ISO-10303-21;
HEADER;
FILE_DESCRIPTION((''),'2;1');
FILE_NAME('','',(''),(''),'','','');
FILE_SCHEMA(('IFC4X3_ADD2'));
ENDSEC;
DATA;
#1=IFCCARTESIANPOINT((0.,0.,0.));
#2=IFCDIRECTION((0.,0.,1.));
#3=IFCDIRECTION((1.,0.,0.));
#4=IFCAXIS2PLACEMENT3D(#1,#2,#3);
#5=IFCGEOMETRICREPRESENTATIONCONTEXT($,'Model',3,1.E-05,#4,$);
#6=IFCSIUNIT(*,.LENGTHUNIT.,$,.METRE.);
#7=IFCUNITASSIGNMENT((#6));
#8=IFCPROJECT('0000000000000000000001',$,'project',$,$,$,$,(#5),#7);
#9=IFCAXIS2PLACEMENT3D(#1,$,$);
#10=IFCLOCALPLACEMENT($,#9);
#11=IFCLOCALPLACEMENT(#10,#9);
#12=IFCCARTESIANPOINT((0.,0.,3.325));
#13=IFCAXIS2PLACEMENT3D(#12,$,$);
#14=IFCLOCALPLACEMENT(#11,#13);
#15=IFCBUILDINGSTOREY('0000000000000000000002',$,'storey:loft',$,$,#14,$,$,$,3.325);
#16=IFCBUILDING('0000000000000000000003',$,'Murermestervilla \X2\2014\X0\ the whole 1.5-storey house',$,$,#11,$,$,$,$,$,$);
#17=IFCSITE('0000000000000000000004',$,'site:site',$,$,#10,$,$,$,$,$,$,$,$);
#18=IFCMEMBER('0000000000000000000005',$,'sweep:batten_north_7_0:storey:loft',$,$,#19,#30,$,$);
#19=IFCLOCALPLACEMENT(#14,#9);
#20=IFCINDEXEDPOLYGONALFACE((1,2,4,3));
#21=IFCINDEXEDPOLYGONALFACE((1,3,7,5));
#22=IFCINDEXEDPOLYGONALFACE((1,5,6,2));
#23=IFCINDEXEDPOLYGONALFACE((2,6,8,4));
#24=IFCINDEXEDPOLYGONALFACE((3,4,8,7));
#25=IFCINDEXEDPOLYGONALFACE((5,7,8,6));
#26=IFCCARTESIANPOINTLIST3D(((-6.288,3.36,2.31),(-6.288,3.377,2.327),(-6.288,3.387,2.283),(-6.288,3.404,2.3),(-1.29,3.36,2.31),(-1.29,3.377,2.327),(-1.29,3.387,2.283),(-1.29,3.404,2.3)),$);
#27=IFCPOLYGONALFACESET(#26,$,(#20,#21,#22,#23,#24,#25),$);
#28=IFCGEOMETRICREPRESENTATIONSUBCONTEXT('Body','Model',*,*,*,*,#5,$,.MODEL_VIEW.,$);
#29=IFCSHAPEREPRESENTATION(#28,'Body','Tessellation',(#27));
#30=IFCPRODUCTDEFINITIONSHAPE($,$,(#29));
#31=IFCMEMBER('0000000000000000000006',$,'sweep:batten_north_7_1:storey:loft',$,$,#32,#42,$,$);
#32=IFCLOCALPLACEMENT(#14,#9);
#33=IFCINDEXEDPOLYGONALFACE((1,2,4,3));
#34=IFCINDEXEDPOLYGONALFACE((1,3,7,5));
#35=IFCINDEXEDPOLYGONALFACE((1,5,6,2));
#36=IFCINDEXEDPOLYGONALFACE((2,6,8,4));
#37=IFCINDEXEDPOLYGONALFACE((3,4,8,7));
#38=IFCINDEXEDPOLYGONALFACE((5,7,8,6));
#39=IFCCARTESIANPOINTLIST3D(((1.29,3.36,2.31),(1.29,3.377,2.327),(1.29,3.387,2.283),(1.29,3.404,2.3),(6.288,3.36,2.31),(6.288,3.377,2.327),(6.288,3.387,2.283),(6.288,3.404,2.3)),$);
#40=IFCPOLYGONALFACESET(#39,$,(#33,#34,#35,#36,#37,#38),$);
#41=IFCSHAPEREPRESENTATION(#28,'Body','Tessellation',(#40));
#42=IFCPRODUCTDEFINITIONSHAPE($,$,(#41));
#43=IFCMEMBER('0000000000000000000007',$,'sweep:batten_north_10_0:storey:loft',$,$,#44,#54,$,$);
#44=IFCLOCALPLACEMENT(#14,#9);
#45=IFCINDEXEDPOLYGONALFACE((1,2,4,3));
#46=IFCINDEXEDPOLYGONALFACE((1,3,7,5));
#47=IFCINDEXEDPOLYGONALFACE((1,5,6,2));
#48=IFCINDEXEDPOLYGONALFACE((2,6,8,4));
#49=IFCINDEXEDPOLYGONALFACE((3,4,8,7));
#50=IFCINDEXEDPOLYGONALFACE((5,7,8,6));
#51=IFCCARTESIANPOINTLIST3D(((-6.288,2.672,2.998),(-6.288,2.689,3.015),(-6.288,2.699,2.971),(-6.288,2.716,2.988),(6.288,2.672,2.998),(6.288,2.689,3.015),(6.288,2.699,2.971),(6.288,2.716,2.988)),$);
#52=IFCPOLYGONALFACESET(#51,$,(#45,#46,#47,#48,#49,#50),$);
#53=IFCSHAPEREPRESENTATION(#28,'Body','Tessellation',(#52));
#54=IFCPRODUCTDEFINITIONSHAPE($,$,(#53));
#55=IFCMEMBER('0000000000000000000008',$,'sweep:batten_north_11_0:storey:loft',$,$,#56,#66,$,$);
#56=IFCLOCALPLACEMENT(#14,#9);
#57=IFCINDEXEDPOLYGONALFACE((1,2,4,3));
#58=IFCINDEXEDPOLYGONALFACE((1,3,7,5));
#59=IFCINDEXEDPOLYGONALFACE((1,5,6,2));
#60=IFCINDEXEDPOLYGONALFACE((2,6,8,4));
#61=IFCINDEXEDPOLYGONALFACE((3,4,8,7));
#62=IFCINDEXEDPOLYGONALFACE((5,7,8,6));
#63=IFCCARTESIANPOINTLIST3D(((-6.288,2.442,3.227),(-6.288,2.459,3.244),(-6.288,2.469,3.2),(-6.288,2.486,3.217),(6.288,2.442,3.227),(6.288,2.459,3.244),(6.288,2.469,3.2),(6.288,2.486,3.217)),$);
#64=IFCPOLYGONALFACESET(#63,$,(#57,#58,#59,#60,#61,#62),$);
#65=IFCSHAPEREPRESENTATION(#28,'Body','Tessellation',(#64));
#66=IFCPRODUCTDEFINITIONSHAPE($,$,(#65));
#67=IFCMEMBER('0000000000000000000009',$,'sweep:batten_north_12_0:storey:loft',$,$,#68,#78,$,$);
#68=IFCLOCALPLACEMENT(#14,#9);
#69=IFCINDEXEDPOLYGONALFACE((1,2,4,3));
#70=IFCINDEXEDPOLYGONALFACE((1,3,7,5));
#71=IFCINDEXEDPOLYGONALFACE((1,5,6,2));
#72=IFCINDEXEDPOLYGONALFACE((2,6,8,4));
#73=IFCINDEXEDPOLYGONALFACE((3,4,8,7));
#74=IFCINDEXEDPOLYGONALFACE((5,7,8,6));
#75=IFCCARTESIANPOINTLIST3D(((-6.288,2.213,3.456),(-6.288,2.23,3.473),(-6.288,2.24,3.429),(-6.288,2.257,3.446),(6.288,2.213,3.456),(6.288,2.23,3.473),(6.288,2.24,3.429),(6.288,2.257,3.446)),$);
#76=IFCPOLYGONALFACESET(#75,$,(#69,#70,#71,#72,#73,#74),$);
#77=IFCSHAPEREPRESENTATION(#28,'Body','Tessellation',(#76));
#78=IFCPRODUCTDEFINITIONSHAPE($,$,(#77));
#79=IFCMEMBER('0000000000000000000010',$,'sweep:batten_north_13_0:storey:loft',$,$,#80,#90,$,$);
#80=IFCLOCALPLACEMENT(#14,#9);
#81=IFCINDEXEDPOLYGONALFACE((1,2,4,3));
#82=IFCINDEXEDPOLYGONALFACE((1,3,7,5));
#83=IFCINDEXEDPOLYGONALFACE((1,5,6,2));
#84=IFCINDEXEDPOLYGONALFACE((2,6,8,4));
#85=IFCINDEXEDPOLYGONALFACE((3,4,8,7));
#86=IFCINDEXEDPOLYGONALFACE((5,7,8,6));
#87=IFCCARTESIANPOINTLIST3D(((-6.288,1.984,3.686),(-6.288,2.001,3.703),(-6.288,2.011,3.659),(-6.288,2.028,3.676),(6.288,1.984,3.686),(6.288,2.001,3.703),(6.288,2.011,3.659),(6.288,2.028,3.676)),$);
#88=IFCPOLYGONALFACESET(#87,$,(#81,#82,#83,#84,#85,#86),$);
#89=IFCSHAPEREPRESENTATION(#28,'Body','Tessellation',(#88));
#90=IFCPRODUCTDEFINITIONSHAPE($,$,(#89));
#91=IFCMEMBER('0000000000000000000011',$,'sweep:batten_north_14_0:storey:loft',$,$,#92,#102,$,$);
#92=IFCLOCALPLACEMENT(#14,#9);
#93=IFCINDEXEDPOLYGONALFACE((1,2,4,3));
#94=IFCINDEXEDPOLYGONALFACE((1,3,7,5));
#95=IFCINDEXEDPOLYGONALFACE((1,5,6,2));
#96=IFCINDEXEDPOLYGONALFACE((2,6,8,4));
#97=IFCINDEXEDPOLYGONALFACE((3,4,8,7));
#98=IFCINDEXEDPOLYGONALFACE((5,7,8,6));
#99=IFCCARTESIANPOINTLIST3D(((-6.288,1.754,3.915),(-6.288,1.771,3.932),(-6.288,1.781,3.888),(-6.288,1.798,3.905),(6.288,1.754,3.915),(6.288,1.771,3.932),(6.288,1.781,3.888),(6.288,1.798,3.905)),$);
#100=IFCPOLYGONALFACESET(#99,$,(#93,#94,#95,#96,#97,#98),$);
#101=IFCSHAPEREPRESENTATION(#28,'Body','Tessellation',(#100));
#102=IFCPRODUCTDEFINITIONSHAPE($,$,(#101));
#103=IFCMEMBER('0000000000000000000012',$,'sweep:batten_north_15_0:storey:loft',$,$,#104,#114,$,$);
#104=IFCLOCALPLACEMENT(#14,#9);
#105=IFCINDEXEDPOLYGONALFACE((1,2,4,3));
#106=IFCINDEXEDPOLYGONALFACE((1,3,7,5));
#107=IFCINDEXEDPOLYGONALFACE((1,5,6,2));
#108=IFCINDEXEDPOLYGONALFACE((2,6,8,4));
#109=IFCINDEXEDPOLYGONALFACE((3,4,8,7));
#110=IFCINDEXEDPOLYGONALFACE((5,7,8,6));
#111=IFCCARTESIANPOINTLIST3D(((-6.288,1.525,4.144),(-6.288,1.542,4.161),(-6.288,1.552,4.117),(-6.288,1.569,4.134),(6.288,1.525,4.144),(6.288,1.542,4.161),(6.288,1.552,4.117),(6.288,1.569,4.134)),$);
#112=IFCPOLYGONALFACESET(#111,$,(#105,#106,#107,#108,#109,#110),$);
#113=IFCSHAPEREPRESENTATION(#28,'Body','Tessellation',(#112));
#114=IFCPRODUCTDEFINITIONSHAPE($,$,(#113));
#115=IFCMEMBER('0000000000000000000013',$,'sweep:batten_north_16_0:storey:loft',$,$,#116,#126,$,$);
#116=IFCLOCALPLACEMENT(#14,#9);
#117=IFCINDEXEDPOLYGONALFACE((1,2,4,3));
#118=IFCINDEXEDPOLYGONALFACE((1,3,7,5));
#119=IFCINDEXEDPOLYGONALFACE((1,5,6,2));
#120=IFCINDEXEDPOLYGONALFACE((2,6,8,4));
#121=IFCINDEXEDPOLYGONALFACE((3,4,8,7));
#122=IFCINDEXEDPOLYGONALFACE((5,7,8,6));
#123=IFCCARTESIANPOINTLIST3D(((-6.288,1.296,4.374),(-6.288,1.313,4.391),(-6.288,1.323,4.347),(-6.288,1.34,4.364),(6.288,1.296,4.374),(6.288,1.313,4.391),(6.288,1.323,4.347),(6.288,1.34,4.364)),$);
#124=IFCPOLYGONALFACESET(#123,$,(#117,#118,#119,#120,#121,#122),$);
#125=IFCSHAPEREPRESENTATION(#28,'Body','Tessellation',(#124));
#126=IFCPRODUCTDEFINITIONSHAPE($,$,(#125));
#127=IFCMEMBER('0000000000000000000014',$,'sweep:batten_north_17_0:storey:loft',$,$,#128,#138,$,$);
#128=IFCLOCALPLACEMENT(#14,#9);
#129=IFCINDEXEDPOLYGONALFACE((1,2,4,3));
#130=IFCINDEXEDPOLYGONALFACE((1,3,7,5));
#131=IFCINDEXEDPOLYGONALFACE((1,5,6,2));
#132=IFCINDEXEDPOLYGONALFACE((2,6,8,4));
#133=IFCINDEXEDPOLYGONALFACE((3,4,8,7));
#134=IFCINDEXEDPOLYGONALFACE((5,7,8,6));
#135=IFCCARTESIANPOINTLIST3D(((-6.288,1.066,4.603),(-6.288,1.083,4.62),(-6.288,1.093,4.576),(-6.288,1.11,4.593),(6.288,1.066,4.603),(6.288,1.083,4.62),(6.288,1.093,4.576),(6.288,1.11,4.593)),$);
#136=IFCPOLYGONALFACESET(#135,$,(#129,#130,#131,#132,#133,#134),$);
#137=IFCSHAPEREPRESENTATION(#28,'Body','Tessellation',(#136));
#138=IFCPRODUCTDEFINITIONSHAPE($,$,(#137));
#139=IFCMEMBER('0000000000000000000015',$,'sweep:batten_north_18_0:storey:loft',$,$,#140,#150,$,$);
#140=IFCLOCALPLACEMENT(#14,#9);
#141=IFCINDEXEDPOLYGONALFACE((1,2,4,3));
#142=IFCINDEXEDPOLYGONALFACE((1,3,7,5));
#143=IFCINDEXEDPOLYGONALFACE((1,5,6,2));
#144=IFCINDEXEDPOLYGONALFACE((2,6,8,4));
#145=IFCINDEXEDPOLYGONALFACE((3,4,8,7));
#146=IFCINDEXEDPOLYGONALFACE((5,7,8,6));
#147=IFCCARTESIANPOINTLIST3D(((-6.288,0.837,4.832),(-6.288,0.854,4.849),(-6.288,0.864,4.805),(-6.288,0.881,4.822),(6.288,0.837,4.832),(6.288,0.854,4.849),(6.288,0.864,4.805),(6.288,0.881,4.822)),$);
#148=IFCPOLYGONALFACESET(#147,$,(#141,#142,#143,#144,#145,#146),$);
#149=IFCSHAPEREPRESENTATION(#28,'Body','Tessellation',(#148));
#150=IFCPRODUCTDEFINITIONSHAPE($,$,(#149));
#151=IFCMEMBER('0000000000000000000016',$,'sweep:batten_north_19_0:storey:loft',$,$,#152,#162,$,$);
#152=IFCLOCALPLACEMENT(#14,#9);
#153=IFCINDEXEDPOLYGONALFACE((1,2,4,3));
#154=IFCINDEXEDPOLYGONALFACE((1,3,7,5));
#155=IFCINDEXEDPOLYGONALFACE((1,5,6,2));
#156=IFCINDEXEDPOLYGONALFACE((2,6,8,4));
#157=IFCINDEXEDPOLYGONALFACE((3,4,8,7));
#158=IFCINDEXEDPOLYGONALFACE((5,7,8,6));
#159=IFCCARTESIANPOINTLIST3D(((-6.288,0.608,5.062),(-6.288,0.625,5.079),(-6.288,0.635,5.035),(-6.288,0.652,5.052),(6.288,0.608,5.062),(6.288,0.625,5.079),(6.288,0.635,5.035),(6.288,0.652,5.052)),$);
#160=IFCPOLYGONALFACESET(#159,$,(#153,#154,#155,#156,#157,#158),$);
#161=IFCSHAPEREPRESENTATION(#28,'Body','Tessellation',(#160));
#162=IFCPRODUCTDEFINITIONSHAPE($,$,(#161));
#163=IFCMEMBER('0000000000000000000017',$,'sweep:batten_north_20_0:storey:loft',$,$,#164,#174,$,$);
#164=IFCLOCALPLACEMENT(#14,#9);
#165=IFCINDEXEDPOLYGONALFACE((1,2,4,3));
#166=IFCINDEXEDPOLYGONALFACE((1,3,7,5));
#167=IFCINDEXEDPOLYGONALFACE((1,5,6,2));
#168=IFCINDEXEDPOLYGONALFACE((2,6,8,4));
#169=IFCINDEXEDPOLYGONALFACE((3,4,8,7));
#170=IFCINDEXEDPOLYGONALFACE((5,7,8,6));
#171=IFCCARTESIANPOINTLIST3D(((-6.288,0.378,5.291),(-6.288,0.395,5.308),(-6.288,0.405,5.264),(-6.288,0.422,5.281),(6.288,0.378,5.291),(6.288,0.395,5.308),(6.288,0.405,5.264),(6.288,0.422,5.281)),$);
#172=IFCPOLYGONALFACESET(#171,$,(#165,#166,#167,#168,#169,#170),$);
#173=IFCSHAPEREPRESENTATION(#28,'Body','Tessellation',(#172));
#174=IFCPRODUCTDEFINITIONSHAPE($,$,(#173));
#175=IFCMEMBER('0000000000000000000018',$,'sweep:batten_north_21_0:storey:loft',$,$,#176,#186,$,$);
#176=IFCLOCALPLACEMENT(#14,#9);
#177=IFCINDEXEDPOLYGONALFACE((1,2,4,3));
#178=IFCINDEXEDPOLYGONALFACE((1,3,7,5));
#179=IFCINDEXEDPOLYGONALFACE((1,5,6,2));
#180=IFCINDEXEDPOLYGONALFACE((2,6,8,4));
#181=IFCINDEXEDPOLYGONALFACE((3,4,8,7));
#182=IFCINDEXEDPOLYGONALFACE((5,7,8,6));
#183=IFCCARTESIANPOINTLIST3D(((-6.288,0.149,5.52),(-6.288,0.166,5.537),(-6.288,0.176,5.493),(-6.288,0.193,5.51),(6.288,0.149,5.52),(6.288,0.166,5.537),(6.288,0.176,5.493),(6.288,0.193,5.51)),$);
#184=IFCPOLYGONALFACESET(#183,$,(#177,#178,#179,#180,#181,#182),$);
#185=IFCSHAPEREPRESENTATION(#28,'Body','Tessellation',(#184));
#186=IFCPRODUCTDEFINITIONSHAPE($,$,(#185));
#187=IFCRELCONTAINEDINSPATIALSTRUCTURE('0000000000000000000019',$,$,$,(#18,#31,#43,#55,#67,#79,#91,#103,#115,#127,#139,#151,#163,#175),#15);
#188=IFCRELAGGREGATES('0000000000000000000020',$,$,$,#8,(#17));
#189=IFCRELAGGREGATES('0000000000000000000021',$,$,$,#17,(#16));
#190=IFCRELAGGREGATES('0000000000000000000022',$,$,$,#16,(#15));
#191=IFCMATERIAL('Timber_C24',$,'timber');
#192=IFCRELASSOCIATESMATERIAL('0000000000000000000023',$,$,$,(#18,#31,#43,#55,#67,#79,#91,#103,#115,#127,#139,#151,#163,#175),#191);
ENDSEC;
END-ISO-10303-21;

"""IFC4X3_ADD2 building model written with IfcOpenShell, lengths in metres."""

from ifc_helpers import new_model, si_unit, frame, origin, origin_with_axes, place, context, subcontext, project, spatial, polyline, outline, extrude, material, element, save


model = new_model("IFC4X3_ADD2")

# Units and contexts
model_context = context("Model", 3, precision=1e-05, world=origin_with_axes())
body_context = subcontext(model_context, "Body", "Model", "MODEL_VIEW")
ifc_project = project(units=[si_unit("LENGTHUNIT", "METRE")], contexts=[model_context])

# Site, building, storey
placement_1 = place(None, origin())
site = spatial("IfcSite", under=ifc_project, at=placement_1, Name="site:site")
building_placement = place(placement_1, origin())
building = spatial("IfcBuilding", under=site, at=building_placement, Name="Murermestervilla — the whole 1.5-storey house")
storey_placement = place(building_placement, frame((0.0, 0.0, 3.325)))
storey = spatial("IfcBuildingStorey", under=building, at=storey_placement, Name="storey:loft", Elevation=3.325)

# Members
ifc_material_1 = material(Name="Timber_C24", Category="timber")
placement_2 = place(storey_placement, frame((0.0, 0.0, -3.325)))
element("IfcMember", 1, at=placement_2, inside=storey, material=ifc_material_1, Name="sweep:batten_north_7_0:storey:loft", context=body_context, shape_type="SweptSolid", body=[
    extrude(outline(polyline([(0.022, -0.005), (-0.005, 0.022), (-0.022, 0.005), (0.005, -0.022), (0.022, -0.005)])), frame((-6.288, 3.382, 5.63), z_axis=(1.0, 0.0, 0.0), x_axis=(0.0, 1.0, 0.0)), (0.0, 0.0, 1.0), 4.998),
])
element("IfcMember", 2, at=placement_2, inside=storey, material=ifc_material_1, Name="sweep:batten_north_7_1:storey:loft", context=body_context, shape_type="SweptSolid", body=[
    extrude(outline(polyline([(0.022, -0.005), (-0.005, 0.022), (-0.022, 0.005), (0.005, -0.022), (0.022, -0.005)])), frame((1.29, 3.382, 5.63), z_axis=(1.0, 0.0, 0.0), x_axis=(0.0, 1.0, 0.0)), (0.0, 0.0, 1.0), 4.998),
])
element("IfcMember", 3, at=placement_2, inside=storey, material=ifc_material_1, Name="sweep:batten_north_10_0:storey:loft", context=body_context, shape_type="SweptSolid", body=[
    extrude(outline(polyline([(0.022, -0.005), (-0.005, 0.022), (-0.022, 0.005), (0.005, -0.022), (0.022, -0.005)])), frame((-6.288, 2.694, 6.318), z_axis=(1.0, 0.0, 0.0), x_axis=(0.0, 1.0, 0.0)), (0.0, 0.0, 1.0), 12.576),
])
element("IfcMember", 4, at=placement_2, inside=storey, material=ifc_material_1, Name="sweep:batten_north_11_0:storey:loft", context=body_context, shape_type="SweptSolid", body=[
    extrude(outline(polyline([(0.022, -0.005), (-0.005, 0.022), (-0.022, 0.005), (0.005, -0.022), (0.022, -0.005)])), frame((-6.288, 2.464, 6.547), z_axis=(1.0, 0.0, 0.0), x_axis=(0.0, 1.0, 0.0)), (0.0, 0.0, 1.0), 12.576),
])
element("IfcMember", 5, at=placement_2, inside=storey, material=ifc_material_1, Name="sweep:batten_north_12_0:storey:loft", context=body_context, shape_type="SweptSolid", body=[
    extrude(outline(polyline([(0.022, -0.005), (-0.005, 0.022), (-0.022, 0.005), (0.005, -0.022), (0.022, -0.005)])), frame((-6.288, 2.235, 6.776), z_axis=(1.0, 0.0, 0.0), x_axis=(0.0, 1.0, 0.0)), (0.0, 0.0, 1.0), 12.576),
])
element("IfcMember", 6, at=placement_2, inside=storey, material=ifc_material_1, Name="sweep:batten_north_13_0:storey:loft", context=body_context, shape_type="SweptSolid", body=[
    extrude(outline(polyline([(0.022, -0.005), (-0.005, 0.022), (-0.022, 0.005), (0.005, -0.022), (0.022, -0.005)])), frame((-6.288, 2.006, 7.006), z_axis=(1.0, 0.0, 0.0), x_axis=(0.0, 1.0, 0.0)), (0.0, 0.0, 1.0), 12.576),
])
element("IfcMember", 7, at=placement_2, inside=storey, material=ifc_material_1, Name="sweep:batten_north_14_0:storey:loft", context=body_context, shape_type="SweptSolid", body=[
    extrude(outline(polyline([(0.022, -0.005), (-0.005, 0.022), (-0.022, 0.005), (0.005, -0.022), (0.022, -0.005)])), frame((-6.288, 1.776, 7.235), z_axis=(1.0, 0.0, 0.0), x_axis=(0.0, 1.0, 0.0)), (0.0, 0.0, 1.0), 12.576),
])
element("IfcMember", 8, at=placement_2, inside=storey, material=ifc_material_1, Name="sweep:batten_north_15_0:storey:loft", context=body_context, shape_type="SweptSolid", body=[
    extrude(outline(polyline([(0.022, -0.005), (-0.005, 0.022), (-0.022, 0.005), (0.005, -0.022), (0.022, -0.005)])), frame((-6.288, 1.547, 7.464), z_axis=(1.0, 0.0, 0.0), x_axis=(0.0, 1.0, 0.0)), (0.0, 0.0, 1.0), 12.576),
])
element("IfcMember", 9, at=placement_2, inside=storey, material=ifc_material_1, Name="sweep:batten_north_16_0:storey:loft", context=body_context, shape_type="SweptSolid", body=[
    extrude(outline(polyline([(0.022, -0.005), (-0.005, 0.022), (-0.022, 0.005), (0.005, -0.022), (0.022, -0.005)])), frame((-6.288, 1.318, 7.694), z_axis=(1.0, 0.0, 0.0), x_axis=(0.0, 1.0, 0.0)), (0.0, 0.0, 1.0), 12.576),
])
element("IfcMember", 10, at=placement_2, inside=storey, material=ifc_material_1, Name="sweep:batten_north_17_0:storey:loft", context=body_context, shape_type="SweptSolid", body=[
    extrude(outline(polyline([(0.022, -0.005), (-0.005, 0.022), (-0.022, 0.005), (0.005, -0.022), (0.022, -0.005)])), frame((-6.288, 1.088, 7.923), z_axis=(1.0, 0.0, 0.0), x_axis=(0.0, 1.0, 0.0)), (0.0, 0.0, 1.0), 12.576),
])
element("IfcMember", 11, at=placement_2, inside=storey, material=ifc_material_1, Name="sweep:batten_north_18_0:storey:loft", context=body_context, shape_type="SweptSolid", body=[
    extrude(outline(polyline([(0.022, -0.005), (-0.005, 0.022), (-0.022, 0.005), (0.005, -0.022), (0.022, -0.005)])), frame((-6.288, 0.859, 8.152), z_axis=(1.0, 0.0, 0.0), x_axis=(0.0, 1.0, 0.0)), (0.0, 0.0, 1.0), 12.576),
])
element("IfcMember", 12, at=placement_2, inside=storey, material=ifc_material_1, Name="sweep:batten_north_19_0:storey:loft", context=body_context, shape_type="SweptSolid", body=[
    extrude(outline(polyline([(0.022, -0.005), (-0.005, 0.022), (-0.022, 0.005), (0.005, -0.022), (0.022, -0.005)])), frame((-6.288, 0.63, 8.382), z_axis=(1.0, 0.0, 0.0), x_axis=(0.0, 1.0, 0.0)), (0.0, 0.0, 1.0), 12.576),
])
element("IfcMember", 13, at=placement_2, inside=storey, material=ifc_material_1, Name="sweep:batten_north_20_0:storey:loft", context=body_context, shape_type="SweptSolid", body=[
    extrude(outline(polyline([(0.022, -0.005), (-0.005, 0.022), (-0.022, 0.005), (0.005, -0.022), (0.022, -0.005)])), frame((-6.288, 0.4, 8.611), z_axis=(1.0, 0.0, 0.0), x_axis=(0.0, 1.0, 0.0)), (0.0, 0.0, 1.0), 12.576),
])
element("IfcMember", 14, at=placement_2, inside=storey, material=ifc_material_1, Name="sweep:batten_north_21_0:storey:loft", context=body_context, shape_type="SweptSolid", body=[
    extrude(outline(polyline([(0.022, -0.005), (-0.005, 0.022), (-0.022, 0.005), (0.005, -0.022), (0.022, -0.005)])), frame((-6.288, 0.171, 8.84), z_axis=(1.0, 0.0, 0.0), x_axis=(0.0, 1.0, 0.0)), (0.0, 0.0, 1.0), 12.576),
])

save(model, "model.ifc")
